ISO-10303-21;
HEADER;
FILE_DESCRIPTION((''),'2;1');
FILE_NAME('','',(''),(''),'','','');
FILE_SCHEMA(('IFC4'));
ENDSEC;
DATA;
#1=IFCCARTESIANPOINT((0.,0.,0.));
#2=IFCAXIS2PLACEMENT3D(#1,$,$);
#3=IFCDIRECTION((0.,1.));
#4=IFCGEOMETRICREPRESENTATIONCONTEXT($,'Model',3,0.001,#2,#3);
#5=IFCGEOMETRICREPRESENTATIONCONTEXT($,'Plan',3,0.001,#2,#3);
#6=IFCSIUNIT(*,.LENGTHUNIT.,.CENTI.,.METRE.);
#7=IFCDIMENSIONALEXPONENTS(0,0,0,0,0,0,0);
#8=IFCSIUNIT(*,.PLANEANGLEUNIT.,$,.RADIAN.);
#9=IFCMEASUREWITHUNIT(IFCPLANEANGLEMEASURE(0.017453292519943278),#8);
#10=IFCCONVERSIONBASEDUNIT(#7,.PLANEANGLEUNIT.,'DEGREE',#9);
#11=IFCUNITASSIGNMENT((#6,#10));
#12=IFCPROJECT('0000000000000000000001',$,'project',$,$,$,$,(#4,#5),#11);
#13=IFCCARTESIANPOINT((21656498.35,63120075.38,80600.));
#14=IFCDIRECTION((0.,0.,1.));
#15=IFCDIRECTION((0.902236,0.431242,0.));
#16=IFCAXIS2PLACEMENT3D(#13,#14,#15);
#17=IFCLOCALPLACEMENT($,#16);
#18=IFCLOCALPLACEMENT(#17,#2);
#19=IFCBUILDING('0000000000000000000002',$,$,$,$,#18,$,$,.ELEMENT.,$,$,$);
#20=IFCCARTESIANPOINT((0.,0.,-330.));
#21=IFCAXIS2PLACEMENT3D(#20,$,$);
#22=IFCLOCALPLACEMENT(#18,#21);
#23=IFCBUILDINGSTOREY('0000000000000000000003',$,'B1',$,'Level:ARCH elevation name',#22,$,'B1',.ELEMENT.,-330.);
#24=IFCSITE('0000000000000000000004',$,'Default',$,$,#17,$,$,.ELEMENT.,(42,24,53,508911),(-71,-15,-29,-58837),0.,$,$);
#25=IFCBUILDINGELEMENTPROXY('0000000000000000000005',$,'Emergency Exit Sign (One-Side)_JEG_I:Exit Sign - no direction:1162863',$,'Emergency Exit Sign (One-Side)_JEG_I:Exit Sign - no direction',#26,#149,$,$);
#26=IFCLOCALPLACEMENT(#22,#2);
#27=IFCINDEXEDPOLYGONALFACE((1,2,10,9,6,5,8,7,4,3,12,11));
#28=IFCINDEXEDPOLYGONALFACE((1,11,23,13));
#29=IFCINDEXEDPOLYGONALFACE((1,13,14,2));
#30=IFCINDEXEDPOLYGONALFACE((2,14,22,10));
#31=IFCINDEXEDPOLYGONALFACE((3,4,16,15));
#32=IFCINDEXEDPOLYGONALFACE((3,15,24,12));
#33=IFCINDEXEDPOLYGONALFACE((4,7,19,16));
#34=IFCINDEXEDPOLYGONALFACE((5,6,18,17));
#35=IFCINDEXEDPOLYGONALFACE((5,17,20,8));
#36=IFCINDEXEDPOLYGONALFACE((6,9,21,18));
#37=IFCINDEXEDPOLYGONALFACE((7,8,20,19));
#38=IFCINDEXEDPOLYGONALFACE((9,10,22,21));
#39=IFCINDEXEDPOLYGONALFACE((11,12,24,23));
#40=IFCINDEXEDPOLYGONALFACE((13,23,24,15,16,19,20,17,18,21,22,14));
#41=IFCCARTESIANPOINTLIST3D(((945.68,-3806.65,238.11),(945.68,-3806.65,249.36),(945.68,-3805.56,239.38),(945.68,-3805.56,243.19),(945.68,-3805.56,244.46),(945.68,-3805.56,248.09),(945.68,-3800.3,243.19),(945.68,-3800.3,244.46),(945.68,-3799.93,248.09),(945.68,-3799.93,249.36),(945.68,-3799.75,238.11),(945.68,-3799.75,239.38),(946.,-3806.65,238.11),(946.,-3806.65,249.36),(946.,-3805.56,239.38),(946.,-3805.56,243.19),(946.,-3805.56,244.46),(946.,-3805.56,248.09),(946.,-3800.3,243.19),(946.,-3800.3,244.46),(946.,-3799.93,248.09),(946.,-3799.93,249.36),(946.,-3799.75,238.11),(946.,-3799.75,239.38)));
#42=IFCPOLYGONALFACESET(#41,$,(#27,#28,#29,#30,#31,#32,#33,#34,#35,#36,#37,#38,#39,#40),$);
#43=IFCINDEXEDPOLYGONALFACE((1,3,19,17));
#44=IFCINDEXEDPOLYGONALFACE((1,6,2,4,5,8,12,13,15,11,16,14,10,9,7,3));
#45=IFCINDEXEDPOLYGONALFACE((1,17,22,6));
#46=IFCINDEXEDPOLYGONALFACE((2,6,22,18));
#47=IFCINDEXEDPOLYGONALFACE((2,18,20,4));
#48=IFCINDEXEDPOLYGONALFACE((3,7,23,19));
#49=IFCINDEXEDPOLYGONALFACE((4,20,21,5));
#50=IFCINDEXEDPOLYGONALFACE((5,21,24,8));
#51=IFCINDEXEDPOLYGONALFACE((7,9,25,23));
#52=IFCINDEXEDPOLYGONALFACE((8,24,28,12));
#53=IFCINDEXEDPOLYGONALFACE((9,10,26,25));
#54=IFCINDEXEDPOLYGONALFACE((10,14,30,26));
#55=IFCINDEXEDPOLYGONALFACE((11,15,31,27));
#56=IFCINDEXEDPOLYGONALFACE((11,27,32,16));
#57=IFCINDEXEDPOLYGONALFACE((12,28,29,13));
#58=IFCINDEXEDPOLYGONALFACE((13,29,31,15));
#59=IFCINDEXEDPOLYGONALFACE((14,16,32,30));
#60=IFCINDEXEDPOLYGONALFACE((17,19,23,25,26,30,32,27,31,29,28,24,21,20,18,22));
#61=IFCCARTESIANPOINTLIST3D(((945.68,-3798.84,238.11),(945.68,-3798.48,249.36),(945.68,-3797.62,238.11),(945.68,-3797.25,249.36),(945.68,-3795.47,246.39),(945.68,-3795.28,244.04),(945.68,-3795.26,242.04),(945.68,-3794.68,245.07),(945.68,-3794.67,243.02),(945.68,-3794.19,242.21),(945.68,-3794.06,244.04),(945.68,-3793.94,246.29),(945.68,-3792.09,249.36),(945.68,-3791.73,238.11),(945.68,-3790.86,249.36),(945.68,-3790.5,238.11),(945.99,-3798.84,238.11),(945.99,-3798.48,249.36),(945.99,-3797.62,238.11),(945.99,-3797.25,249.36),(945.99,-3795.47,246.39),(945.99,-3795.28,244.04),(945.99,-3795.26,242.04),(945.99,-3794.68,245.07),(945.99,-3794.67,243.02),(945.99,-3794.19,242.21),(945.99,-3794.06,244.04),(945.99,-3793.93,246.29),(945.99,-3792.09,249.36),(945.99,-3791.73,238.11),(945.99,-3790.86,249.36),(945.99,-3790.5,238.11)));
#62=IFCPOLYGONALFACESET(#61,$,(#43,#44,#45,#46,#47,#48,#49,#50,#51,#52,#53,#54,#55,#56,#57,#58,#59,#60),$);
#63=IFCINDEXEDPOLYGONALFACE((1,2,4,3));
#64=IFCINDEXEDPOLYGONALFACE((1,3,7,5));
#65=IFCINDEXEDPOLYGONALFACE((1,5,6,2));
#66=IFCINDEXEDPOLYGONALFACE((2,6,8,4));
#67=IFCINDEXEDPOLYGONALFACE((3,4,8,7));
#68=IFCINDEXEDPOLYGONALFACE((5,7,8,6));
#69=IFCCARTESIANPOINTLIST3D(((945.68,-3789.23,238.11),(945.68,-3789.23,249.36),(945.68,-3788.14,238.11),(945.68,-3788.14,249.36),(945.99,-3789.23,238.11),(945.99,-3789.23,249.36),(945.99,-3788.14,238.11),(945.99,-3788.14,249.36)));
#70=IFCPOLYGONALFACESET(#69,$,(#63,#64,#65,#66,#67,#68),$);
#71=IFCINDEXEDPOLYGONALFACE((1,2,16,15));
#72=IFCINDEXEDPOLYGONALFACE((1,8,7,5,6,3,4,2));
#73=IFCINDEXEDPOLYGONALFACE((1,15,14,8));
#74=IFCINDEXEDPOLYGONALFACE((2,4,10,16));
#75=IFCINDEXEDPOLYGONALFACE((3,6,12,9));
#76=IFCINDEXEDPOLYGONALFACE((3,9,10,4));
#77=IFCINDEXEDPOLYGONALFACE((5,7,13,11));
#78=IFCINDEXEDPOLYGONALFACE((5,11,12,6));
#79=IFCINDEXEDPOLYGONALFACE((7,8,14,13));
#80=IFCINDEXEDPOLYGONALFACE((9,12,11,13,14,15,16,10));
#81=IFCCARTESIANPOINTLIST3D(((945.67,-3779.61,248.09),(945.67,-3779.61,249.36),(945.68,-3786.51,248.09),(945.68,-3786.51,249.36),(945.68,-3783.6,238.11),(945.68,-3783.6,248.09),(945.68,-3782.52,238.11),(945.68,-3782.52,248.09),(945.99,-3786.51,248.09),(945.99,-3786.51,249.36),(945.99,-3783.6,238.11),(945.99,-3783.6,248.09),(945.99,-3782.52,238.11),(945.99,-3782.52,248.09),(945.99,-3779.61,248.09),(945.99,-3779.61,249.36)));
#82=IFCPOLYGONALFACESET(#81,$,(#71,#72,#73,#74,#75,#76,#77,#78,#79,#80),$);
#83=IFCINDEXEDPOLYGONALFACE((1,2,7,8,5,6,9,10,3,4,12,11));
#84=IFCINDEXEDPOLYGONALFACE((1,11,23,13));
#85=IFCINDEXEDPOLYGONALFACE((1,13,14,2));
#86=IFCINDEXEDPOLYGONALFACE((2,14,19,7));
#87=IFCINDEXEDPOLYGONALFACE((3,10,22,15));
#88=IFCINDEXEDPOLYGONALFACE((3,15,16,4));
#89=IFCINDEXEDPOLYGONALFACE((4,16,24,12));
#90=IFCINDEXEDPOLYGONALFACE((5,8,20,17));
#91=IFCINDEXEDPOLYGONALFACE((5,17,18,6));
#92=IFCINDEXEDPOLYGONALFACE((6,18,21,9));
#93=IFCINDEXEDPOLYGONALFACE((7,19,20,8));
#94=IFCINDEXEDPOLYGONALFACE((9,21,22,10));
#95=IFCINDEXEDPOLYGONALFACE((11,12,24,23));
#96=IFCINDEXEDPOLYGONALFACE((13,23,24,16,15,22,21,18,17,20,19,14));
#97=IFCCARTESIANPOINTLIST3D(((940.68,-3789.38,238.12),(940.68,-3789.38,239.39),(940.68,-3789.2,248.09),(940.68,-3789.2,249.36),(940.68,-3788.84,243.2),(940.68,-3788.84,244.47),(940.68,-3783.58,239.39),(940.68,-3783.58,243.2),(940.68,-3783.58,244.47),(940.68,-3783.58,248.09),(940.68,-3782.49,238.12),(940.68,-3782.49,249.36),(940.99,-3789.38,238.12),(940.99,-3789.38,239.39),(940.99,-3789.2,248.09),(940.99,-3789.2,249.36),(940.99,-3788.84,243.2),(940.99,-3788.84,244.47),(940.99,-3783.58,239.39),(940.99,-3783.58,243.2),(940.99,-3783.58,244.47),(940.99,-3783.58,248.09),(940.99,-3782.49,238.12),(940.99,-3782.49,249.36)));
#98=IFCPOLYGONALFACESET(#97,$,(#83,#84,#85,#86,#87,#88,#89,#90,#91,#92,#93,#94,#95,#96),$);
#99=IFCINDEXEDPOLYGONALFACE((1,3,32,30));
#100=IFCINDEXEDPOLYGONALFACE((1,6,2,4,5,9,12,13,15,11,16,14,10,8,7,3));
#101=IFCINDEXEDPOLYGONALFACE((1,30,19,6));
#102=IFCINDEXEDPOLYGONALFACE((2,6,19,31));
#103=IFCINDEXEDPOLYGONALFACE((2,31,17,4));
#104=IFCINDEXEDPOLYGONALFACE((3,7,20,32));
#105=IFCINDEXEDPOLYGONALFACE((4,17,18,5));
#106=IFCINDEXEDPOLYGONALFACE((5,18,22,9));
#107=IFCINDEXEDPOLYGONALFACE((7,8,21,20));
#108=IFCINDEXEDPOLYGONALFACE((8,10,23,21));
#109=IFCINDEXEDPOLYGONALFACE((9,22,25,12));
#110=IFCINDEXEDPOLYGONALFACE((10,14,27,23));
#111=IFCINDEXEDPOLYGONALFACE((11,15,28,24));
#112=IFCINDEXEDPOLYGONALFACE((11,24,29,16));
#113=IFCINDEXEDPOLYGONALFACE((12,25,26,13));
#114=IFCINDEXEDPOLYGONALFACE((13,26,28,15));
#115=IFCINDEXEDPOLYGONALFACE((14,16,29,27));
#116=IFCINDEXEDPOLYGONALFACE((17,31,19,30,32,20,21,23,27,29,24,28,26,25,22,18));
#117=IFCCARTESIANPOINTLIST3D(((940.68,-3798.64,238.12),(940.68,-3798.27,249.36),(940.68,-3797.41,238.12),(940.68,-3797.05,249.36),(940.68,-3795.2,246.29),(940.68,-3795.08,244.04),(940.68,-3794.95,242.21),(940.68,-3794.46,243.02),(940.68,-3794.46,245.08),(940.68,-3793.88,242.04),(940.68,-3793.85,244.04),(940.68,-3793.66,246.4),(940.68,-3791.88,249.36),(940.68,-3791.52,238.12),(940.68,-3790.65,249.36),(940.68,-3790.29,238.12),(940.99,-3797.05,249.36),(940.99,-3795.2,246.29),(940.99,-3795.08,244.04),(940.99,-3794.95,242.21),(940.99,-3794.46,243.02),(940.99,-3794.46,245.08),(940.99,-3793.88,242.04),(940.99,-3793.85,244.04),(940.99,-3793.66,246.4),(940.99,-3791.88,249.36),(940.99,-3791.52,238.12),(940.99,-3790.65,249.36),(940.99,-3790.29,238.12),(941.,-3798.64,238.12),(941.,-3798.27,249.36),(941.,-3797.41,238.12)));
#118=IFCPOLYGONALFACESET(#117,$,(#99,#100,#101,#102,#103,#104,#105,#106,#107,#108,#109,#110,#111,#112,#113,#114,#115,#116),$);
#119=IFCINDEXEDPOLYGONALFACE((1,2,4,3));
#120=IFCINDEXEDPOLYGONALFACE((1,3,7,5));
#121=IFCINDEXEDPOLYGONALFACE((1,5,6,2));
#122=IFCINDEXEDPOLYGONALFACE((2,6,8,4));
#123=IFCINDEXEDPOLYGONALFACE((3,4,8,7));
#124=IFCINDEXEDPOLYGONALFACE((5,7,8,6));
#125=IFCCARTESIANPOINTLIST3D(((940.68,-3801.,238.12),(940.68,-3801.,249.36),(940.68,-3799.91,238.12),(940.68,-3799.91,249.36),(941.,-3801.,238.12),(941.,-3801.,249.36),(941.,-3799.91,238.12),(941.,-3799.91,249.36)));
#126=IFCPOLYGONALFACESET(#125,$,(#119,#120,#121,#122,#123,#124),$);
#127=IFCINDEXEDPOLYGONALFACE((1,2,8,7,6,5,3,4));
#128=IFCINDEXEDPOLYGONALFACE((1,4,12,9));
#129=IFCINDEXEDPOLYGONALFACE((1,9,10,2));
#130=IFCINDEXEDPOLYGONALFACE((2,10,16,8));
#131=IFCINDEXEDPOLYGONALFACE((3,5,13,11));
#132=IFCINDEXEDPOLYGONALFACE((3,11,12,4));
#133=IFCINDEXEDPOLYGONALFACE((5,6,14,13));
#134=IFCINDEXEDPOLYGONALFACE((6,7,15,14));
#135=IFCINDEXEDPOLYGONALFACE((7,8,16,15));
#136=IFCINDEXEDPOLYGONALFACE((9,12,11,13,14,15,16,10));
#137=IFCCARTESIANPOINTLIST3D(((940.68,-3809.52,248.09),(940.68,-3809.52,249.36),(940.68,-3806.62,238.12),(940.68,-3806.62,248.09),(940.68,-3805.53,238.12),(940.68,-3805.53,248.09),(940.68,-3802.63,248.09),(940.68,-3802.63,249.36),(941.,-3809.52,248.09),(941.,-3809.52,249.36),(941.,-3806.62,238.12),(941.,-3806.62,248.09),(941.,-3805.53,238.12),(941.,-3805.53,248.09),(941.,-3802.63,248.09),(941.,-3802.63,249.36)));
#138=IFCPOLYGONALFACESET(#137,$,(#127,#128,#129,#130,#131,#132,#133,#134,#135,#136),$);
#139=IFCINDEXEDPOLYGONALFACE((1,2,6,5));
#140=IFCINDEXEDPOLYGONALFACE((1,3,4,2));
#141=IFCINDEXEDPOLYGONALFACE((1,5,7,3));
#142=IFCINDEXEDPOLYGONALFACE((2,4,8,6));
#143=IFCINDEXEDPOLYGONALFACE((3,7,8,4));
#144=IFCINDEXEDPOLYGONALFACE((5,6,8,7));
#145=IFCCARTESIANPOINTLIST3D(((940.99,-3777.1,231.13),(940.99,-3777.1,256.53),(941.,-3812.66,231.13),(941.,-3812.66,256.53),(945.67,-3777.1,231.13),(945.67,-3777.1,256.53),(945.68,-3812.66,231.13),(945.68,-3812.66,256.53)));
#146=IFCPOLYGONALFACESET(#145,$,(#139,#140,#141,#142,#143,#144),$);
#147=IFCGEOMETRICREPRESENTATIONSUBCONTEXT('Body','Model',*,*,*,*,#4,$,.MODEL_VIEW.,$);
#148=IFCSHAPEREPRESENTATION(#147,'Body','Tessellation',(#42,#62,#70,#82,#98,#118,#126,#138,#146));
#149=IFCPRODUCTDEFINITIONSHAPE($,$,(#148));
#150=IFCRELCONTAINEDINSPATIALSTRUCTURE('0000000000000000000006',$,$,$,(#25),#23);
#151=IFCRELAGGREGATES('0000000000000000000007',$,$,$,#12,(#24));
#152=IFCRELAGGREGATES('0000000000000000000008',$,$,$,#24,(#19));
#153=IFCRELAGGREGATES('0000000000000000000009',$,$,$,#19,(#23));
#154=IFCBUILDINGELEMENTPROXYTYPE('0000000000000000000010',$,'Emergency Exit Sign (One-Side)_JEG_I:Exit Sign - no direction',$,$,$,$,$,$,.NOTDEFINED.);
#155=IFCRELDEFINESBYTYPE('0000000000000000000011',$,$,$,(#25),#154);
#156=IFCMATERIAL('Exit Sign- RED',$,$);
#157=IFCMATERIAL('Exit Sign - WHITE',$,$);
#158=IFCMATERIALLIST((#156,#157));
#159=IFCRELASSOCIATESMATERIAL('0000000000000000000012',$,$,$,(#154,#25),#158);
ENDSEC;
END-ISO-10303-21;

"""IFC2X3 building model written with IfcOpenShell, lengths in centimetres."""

from ifc_helpers import new_model, entity, si_unit, converted_unit, direction, frame, frame_2d, origin, origin_2d_with_axis, place, context, subcontext, project, spatial, polyline, rectangle, outline, extrude, source, transform, mapped, material, material_list, type_object, type_shapes, element, save


model = new_model("IFC2X3")

# Units and contexts
model_context = context("Model", 3, precision=0.001, world=origin(), true_north=direction((0.0, 1.0)))
plan_context = context("Plan", 3, precision=0.001, world=origin(), true_north=direction((0.0, 1.0)))
body_context = subcontext(model_context, "Body", "Model", "MODEL_VIEW")
ifc_project = project(units=[si_unit("LENGTHUNIT", "METRE", prefix="CENTI"), converted_unit("PLANEANGLEUNIT", "DEGREE", entity("IfcPlaneAngleMeasure", 0.017453292519943278), si_unit("PLANEANGLEUNIT", "RADIAN"), dimensions=[0, 0, 0, 0, 0, 0, 0])], contexts=[model_context, plan_context])

# Site, building, storey
site_placement = place(None, frame((21656498.35, 63120075.38, 80600.0), z_axis=(0.0, 0.0, 1.0), x_axis=(0.902236, 0.431242, 0.0)))
site = spatial("IfcSite", under=ifc_project, at=site_placement, Name="Default", CompositionType="ELEMENT", RefLatitude=(42, 24, 53, 508911), RefLongitude=(-71, -15, -29, -58837), RefElevation=0.0)
building_placement = place(site_placement, origin())
building = spatial("IfcBuilding", under=site, at=building_placement, CompositionType="ELEMENT")
storey_placement = place(building_placement, frame((0.0, 0.0, -330.0)))
storey = spatial("IfcBuildingStorey", under=building, at=storey_placement, Name="B1", ObjectType="Level:ARCH elevation name", LongName="B1", CompositionType="ELEMENT", Elevation=-330.0)

# Shared definitions
ifc_material_1 = material(Name="Exit Sign - WHITE")
ifc_material_2 = material(Name="Exit Sign- RED")

# Building element proxy
ifc_material_list_1 = material_list([ifc_material_2, ifc_material_1])
building_element_proxy_type_1 = type_object("IfcBuildingElementProxyType", Name="Emergency Exit Sign (One-Side)_JEG_I:Exit Sign - no direction", PredefinedType="NOTDEFINED", material=ifc_material_list_1)
shared_shape_1 = source(origin(), body_context, "Body", "SweptSolid", [
    extrude(outline(polyline([(-5.65, -3.69), (5.59, -3.69), (5.59, 3.02), (4.32, 3.02), (4.32, -2.6), (0.7, -2.6), (0.7, 2.66), (-0.57, 2.66), (-0.57, -2.6), (-4.38, -2.6), (-4.38, 3.21), (-5.65, 3.21), (-5.65, -3.69)])), frame((-8.08, -5.22, 12.64), z_axis=(0.0, 1.0, 0.0), x_axis=(0.0, 0.0, 1.0)), (0.0, 0.0, 1.0), 0.32),
    extrude(outline(polyline([(-7.14, 0.57), (-6.5, -0.49), (-1.93, -0.48), (-0.78, -0.48), (-1.23, -1.32), (-3.47, -5.53), (-2.84, -6.59), (0.41, -0.48), (6.62, -0.48), (5.99, 0.57), (2.4, 0.57), (0.98, 0.58), (1.7, 1.94), (3.32, 5.0), (2.69, 6.05), (-0.22, 0.57), (-7.14, 0.57)])), frame((0.2, -5.22, 12.81), z_axis=(0.0, -1.0, 0.0), x_axis=(0.515099, 0.0, 0.857131)), (0.0, 0.0, -1.0), 0.32),
    extrude(rectangle(XDim=0.32, YDim=1.09, at=frame_2d((0.0, 0.0), x_axis=(1.0, 0.0))), frame((6.19, -5.06, 6.99), z_axis=(0.0, 0.0, 1.0), x_axis=(0.0, 1.0, 0.0)), (0.0, 0.0, 1.0), 11.25),
    extrude(outline(polyline([(-7.8, 0.54), (-7.8, -0.54), (2.18, -0.54), (2.18, -3.45), (3.45, -3.45), (3.45, 3.45), (2.18, 3.45), (2.18, 0.54), (-7.8, 0.54)])), frame((11.82, -5.22, 14.79), z_axis=(0.0, -1.0, 0.0), x_axis=(0.0, 0.0, 1.0)), (0.0, 0.0, -1.0), 0.32),
    extrude(outline(polyline([(-3.69, -5.65), (3.21, -5.65), (3.21, -4.38), (-2.6, -4.38), (-2.6, -0.57), (2.66, -0.57), (2.66, 0.7), (-2.6, 0.7), (-2.6, 4.32), (3.02, 4.32), (3.02, 5.59), (-3.69, 5.59), (-3.69, -5.65)])), frame((8.7, -0.22, 12.65), z_axis=(0.0, 1.0, 0.0), x_axis=(-1.0, 0.0, 0.0)), (0.0, 0.0, 1.0), 0.32),
    extrude(outline(polyline([(-4.16, -5.82), (-2.93, -5.82), (-0.58, -1.9), (0.01, -0.92), (0.5, -1.73), (2.96, -5.82), (4.18, -5.82), (0.62, 0.1), (3.82, 5.42), (2.59, 5.42), (0.75, 2.35), (0.01, 1.14), (-0.79, 2.46), (-2.57, 5.42), (-3.8, 5.42), (-0.6, 0.1), (-4.16, -5.82)])), frame((0.43, -0.22, 12.82), z_axis=(0.0, 1.0, 0.0), x_axis=(-1.0, 0.0, 0.0)), (0.0, 0.0, 1.0), 0.32),
    extrude(rectangle(XDim=0.32, YDim=1.09, at=origin_2d_with_axis()), frame((-5.57, -0.06, 6.99), z_axis=(0.0, 0.0, 1.0), x_axis=(0.0, -1.0, 0.0)), (0.0, 0.0, 1.0), 11.25),
    extrude(outline(polyline([(-0.54, -7.8), (0.54, -7.8), (0.54, 2.18), (3.45, 2.18), (3.45, 3.45), (-3.45, 3.45), (-3.45, 2.18), (-0.54, 2.18), (-0.54, -7.8)])), frame((-11.2, -0.22, 14.79), z_axis=(0.0, 1.0, 0.0), x_axis=(-1.0, 0.0, 0.0)), (0.0, 0.0, 1.0), 0.32),
    extrude(rectangle(XDim=4.68, YDim=35.56, at=origin_2d_with_axis()), frame((0.0, -2.56, 0.01), z_axis=(0.0, 0.0, 1.0), x_axis=(0.0, 1.0, 0.0)), (0.0, 0.0, 1.0), 25.4),
])
type_shapes(building_element_proxy_type_1, [shared_shape_1])
for number, where, z_axis, x_axis, name in (
    (1, (940.77, -3794.88, 231.12), (0.0, 0.0, 1.0), (-0.000128, 1.0, 0.0), "Emergency Exit Sign (One-Side)_JEG_I:Exit Sign - no direction:1162863"),
):
    element("IfcBuildingElementProxy", number, at=place(storey_placement, frame(where, z_axis=z_axis, x_axis=x_axis)), inside=storey, type_object=building_element_proxy_type_1, material=ifc_material_list_1, Name=name, ObjectType="Emergency Exit Sign (One-Side)_JEG_I:Exit Sign - no direction", context=body_context, shape_type="MappedRepresentation", body=[
        mapped(shared_shape_1, transform((0.0, 0.0, 0.0), scale=1.0)),
    ])

save(model, "model.ifc")
